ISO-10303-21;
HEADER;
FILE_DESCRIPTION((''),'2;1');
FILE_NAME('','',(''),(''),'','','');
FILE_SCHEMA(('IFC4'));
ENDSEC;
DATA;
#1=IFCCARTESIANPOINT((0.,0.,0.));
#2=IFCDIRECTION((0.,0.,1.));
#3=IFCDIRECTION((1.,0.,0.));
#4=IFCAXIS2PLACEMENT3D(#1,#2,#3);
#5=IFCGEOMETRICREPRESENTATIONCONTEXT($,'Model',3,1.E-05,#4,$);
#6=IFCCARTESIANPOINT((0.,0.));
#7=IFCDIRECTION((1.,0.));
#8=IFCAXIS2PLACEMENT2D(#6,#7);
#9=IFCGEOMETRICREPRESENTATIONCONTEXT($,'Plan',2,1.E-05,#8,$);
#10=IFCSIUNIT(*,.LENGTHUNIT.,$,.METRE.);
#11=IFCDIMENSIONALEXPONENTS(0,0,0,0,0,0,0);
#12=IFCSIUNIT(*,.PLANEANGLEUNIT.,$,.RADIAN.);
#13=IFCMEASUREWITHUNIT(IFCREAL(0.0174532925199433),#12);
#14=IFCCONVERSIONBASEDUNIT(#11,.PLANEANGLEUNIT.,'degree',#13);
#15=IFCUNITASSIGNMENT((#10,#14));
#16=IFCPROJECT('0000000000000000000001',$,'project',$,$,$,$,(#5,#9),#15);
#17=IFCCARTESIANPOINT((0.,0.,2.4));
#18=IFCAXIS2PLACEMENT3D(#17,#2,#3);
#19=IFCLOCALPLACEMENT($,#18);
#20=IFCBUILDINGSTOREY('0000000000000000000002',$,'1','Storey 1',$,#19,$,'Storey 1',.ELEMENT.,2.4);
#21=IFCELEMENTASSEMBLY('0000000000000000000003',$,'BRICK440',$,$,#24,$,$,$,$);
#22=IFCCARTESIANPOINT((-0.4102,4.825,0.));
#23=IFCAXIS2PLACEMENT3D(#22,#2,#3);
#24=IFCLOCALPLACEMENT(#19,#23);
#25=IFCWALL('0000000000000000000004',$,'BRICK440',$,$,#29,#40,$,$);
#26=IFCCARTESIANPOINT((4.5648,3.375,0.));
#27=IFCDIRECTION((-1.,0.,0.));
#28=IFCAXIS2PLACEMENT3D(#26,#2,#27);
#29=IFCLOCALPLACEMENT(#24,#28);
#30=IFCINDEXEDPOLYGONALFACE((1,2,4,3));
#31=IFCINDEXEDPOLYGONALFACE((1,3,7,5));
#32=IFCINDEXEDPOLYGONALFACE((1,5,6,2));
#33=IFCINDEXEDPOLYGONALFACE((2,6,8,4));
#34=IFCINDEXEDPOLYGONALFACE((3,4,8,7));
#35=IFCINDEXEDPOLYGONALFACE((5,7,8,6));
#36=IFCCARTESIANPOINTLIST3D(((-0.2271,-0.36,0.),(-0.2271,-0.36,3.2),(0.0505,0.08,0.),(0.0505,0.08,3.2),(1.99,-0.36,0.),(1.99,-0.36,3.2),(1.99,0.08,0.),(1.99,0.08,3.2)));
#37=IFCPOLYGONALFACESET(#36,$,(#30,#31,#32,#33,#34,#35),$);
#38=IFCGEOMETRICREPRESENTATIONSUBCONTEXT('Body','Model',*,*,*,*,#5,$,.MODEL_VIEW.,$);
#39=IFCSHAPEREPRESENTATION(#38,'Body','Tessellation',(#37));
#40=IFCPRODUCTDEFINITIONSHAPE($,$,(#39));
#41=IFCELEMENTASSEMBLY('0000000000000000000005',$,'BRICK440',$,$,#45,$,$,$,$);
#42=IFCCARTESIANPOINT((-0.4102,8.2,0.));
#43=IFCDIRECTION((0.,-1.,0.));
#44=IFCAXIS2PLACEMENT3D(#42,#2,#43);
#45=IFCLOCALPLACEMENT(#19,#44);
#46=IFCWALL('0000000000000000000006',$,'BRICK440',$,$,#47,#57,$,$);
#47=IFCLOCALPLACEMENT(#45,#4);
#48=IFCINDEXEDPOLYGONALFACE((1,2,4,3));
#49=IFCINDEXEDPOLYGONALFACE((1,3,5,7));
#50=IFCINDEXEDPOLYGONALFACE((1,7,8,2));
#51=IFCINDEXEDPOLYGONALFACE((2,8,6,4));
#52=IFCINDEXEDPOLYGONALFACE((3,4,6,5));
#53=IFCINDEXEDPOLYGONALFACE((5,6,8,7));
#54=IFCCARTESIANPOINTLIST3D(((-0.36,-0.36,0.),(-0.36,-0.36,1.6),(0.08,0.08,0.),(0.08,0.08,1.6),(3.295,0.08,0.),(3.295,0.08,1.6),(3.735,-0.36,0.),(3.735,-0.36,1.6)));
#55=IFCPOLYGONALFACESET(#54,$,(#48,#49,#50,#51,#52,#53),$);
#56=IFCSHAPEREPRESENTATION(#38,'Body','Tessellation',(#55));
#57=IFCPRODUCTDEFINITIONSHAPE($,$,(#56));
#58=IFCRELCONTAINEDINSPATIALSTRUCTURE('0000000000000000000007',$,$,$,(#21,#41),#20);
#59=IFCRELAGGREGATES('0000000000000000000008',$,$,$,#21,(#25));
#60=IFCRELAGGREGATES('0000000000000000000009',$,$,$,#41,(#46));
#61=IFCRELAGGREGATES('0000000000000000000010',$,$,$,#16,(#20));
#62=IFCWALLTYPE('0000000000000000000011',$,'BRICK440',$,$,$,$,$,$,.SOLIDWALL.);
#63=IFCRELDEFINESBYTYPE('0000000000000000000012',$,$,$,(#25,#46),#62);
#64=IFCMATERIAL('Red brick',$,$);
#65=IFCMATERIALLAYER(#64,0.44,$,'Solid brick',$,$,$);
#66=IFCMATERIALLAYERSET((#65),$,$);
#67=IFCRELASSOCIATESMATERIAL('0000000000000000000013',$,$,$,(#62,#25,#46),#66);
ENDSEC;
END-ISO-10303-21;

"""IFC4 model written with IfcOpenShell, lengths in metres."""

from ifc_helpers import new_model, entity, si_unit, converted_unit, frame, origin, origin_with_axes, origin_2d_with_axis, place, context, subcontext, project, spatial, polyline, outline, extrude, material, layer, layer_set, layer_usage, type_object, element, aggregate, save


model = new_model("IFC4")

# Units and contexts
model_context = context("Model", 3, precision=1e-05, world=origin_with_axes())
plan_context = context("Plan", 2, precision=1e-05, world=origin_2d_with_axis())
body_context = subcontext(model_context, "Body", "Model", "MODEL_VIEW")
ifc_project = project(units=[si_unit("LENGTHUNIT", "METRE"), converted_unit("PLANEANGLEUNIT", "degree", entity("IfcReal", 0.0174532925199433), si_unit("PLANEANGLEUNIT", "RADIAN"), dimensions=[0, 0, 0, 0, 0, 0, 0])], contexts=[model_context, plan_context])

# Storey
storey_placement = place(None, frame((0.0, 0.0, 2.4), z_axis=(0.0, 0.0, 1.0), x_axis=(1.0, 0.0, 0.0)))
storey = spatial("IfcBuildingStorey", under=ifc_project, at=storey_placement, Name="1", Description="Storey 1", LongName="Storey 1", CompositionType="ELEMENT", Elevation=2.4)

# Element assemblies, walls
assembly_1_placement = place(storey_placement, frame((-0.4102, 4.825, 0.0), z_axis=(0.0, 0.0, 1.0), x_axis=(1.0, 0.0, 0.0)))
assembly_1 = element("IfcElementAssembly", 1, at=assembly_1_placement, inside=storey, Name="BRICK440")
ifc_material_1 = material(Name="Red brick")
ifc_layer_1 = layer(ifc_material_1, 0.44, Name="Solid brick")
ifc_layer_set_1 = layer_set([ifc_layer_1])
ifc_layer_usage_1 = layer_usage(ifc_layer_set_1, "AXIS2", "POSITIVE", -0.36)
wall_type_1 = type_object("IfcWallType", Name="BRICK440", PredefinedType="SOLIDWALL", material=ifc_layer_set_1)
wall_1_placement = place(assembly_1_placement, frame((4.5648, 3.375, 0.0), z_axis=(0.0, 0.0, 1.0), x_axis=(-1.0, 0.0, 0.0)))
wall_1 = element("IfcWall", 2, at=wall_1_placement, type_object=wall_type_1, material=ifc_layer_usage_1, Name="BRICK440", context=body_context, shape_type="SweptSolid", body=[
    extrude(outline(polyline([(0.0505, 0.08), (-0.2271, -0.36), (1.99, -0.36), (1.99, 0.08), (0.0505, 0.08)])), origin(), (0.0, 0.0, 1.0), 3.2),
])
aggregate(assembly_1, [wall_1])
assembly_2_placement = place(storey_placement, frame((-0.4102, 8.2, 0.0), z_axis=(0.0, 0.0, 1.0), x_axis=(0.0, -1.0, 0.0)))
assembly_2 = element("IfcElementAssembly", 3, at=assembly_2_placement, inside=storey, Name="BRICK440")
ifc_layer_usage_2 = layer_usage(ifc_layer_set_1, "AXIS2", "POSITIVE", -0.36)
wall_2_placement = place(assembly_2_placement, origin_with_axes())
wall_2 = element("IfcWall", 4, at=wall_2_placement, type_object=wall_type_1, material=ifc_layer_usage_2, Name="BRICK440", context=body_context, shape_type="SweptSolid", body=[
    extrude(outline(polyline([(0.08, 0.08), (-0.36, -0.36), (3.735, -0.36), (3.295, 0.08), (0.08, 0.08)])), origin(), (0.0, 0.0, 1.0), 1.6),
])
aggregate(assembly_2, [wall_2])

save(model, "model.ifc")
